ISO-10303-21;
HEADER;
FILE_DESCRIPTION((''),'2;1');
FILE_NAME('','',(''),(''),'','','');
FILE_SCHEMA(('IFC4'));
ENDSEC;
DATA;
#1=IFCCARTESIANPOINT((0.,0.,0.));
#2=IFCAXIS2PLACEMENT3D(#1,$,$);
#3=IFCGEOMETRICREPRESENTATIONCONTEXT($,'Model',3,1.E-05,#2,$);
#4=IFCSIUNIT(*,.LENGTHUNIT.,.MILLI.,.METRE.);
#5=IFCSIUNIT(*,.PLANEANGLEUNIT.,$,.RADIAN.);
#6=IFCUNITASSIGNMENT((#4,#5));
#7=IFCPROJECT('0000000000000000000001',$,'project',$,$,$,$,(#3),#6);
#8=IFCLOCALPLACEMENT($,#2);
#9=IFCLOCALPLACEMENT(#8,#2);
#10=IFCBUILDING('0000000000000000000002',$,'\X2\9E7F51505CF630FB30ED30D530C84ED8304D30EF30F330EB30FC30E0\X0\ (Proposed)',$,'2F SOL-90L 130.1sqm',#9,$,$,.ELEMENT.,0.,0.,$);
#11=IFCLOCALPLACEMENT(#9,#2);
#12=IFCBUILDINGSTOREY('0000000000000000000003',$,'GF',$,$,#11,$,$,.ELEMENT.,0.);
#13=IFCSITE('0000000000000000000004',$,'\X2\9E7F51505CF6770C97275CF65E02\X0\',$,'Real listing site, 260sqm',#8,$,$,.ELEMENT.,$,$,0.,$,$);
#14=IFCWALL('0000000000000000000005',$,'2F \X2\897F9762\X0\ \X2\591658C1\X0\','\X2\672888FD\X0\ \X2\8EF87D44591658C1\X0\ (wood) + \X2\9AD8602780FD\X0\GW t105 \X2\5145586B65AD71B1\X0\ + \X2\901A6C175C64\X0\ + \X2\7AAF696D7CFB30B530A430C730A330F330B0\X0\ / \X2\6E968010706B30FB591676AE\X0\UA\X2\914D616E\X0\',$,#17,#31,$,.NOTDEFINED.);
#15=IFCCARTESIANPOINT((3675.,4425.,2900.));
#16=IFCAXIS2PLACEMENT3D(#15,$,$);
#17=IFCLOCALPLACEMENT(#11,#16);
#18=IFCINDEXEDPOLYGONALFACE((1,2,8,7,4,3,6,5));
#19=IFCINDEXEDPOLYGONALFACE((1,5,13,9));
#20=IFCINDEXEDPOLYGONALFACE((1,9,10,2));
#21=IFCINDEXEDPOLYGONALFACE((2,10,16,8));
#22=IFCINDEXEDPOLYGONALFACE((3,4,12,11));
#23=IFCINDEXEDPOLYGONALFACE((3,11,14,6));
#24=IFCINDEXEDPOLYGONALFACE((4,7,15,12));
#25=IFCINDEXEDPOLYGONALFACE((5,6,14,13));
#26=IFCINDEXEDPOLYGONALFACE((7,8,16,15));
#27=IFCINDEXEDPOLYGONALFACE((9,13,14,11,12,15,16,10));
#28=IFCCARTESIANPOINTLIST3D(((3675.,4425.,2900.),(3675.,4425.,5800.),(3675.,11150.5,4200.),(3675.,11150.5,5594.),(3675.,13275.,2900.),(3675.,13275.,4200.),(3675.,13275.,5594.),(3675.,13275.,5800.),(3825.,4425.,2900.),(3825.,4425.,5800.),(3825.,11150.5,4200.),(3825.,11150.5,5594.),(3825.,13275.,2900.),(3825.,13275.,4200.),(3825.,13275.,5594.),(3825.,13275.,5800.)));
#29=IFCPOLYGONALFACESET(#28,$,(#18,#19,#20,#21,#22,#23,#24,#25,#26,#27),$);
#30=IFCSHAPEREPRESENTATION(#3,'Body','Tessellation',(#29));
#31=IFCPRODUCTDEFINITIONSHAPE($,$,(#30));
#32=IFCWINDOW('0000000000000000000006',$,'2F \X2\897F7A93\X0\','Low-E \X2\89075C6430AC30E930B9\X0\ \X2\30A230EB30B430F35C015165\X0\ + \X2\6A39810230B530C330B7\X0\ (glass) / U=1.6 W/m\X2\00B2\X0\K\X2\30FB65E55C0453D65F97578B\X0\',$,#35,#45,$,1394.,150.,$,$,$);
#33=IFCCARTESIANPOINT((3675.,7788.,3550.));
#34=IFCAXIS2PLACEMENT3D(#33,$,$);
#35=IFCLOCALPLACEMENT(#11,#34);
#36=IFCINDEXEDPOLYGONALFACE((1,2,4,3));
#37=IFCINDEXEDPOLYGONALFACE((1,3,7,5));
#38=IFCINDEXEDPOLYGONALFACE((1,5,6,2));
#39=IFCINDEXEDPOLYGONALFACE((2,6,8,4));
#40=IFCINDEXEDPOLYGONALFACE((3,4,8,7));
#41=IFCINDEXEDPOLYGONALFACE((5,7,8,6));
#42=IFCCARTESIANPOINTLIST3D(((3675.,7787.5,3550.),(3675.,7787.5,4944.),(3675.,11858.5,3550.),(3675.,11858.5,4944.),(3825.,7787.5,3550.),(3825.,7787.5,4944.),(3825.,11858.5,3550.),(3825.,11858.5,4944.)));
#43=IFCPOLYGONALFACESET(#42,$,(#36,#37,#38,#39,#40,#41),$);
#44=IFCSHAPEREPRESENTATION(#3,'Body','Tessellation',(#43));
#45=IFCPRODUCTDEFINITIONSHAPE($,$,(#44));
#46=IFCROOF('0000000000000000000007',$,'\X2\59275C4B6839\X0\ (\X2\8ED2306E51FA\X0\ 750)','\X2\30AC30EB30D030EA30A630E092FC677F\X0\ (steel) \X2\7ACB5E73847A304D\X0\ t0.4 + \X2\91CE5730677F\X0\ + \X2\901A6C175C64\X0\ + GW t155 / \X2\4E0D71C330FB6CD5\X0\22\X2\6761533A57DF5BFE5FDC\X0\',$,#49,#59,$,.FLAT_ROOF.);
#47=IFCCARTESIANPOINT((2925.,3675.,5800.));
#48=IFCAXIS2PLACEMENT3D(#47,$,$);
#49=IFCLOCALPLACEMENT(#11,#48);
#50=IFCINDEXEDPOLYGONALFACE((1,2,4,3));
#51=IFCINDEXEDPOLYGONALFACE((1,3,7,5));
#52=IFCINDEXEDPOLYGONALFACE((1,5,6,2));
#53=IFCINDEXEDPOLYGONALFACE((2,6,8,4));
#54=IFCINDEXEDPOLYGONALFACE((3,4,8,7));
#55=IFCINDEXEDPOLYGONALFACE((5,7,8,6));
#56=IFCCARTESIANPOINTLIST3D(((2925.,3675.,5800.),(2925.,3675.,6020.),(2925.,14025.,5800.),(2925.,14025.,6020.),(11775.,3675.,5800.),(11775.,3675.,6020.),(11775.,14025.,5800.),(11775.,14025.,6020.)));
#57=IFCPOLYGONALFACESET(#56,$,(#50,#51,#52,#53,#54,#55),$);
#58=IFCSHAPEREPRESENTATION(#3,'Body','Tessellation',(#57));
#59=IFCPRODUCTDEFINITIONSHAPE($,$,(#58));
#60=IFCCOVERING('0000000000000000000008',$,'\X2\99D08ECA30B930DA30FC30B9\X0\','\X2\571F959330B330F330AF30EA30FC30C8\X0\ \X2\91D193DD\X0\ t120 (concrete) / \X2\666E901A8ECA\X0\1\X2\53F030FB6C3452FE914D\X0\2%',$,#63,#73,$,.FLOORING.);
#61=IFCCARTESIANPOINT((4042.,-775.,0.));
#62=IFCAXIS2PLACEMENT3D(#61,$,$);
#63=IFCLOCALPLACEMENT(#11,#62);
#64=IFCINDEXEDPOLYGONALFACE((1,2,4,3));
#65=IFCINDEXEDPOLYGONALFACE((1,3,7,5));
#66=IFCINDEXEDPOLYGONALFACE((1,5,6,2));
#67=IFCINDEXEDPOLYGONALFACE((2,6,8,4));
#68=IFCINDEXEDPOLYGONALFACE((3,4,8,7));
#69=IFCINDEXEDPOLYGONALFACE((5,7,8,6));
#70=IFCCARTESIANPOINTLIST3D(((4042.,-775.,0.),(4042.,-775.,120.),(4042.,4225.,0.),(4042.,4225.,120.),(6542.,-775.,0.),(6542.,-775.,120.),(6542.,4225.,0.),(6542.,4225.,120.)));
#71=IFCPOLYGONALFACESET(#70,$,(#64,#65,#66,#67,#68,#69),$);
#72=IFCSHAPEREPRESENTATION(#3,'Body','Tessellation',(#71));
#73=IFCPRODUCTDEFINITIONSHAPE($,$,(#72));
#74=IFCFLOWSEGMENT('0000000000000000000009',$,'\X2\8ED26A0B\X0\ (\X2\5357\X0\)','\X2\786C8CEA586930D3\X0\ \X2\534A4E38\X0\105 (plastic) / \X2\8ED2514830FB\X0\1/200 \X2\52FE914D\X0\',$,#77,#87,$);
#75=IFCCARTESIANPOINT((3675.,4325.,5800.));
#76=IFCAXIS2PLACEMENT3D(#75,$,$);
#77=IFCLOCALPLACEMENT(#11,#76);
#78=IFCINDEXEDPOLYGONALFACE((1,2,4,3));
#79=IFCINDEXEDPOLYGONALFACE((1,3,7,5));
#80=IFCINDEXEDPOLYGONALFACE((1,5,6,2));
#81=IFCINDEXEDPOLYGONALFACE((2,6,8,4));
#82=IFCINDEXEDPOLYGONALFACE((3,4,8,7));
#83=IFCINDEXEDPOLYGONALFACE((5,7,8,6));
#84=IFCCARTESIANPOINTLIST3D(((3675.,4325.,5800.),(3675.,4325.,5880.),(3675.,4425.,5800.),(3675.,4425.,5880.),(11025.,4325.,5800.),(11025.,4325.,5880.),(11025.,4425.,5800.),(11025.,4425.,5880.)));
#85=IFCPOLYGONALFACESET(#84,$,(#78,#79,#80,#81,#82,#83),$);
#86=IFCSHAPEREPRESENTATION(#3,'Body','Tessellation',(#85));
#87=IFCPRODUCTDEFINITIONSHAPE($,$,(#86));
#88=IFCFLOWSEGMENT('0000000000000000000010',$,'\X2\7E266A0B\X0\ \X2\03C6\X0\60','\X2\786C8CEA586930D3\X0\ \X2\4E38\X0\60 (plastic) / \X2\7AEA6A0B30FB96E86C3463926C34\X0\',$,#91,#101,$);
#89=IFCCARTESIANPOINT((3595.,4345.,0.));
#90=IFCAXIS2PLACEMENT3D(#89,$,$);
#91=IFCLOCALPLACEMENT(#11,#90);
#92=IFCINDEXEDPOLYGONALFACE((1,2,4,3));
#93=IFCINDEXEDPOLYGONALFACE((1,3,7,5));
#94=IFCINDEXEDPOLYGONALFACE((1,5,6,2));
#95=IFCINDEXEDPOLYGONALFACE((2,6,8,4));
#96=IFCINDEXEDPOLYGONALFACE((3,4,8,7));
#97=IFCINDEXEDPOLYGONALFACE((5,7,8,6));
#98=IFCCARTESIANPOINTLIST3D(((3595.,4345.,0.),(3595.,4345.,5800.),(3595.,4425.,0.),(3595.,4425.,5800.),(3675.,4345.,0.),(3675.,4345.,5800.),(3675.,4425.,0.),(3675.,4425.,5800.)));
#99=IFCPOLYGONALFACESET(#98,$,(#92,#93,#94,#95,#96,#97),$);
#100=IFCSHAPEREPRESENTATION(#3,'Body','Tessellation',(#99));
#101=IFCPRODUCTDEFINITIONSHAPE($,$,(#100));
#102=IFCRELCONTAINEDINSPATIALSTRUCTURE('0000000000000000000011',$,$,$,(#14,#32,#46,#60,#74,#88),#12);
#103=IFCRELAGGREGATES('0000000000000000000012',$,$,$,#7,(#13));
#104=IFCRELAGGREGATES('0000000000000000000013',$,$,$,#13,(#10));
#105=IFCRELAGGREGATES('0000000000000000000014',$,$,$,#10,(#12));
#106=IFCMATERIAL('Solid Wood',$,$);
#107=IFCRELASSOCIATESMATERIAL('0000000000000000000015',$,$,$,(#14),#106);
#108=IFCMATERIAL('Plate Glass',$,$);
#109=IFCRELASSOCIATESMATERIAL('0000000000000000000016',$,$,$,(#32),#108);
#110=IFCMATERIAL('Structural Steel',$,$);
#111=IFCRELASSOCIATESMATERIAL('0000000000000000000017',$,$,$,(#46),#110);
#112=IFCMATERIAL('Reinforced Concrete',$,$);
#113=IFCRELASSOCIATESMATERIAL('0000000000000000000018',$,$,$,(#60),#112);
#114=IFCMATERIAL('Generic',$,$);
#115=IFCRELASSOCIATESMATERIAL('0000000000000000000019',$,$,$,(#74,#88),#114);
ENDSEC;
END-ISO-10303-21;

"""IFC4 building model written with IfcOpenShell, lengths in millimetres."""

from ifc_helpers import new_model, si_unit, frame, frame_2d, origin, place, context, project, spatial, rectangle, extrude, material, element, fill, save


model = new_model("IFC4")

# Units and contexts
model_context = context("Model", 3, precision=1e-05, world=origin())
ifc_project = project(units=[si_unit("LENGTHUNIT", "METRE", prefix="MILLI"), si_unit("PLANEANGLEUNIT", "RADIAN")], contexts=[model_context])

# Site, building, storey
site_placement = place(None, origin())
site = spatial("IfcSite", under=ifc_project, at=site_placement, Name="鹿児島県霧島市", ObjectType="Real listing site, 260sqm", CompositionType="ELEMENT", RefElevation=0.0)
building_placement = place(site_placement, origin())
building = spatial("IfcBuilding", under=site, at=building_placement, Name="鹿児島・ロフト付きワンルーム (Proposed)", ObjectType="2F SOL-90L 130.1sqm", CompositionType="ELEMENT", ElevationOfRefHeight=0.0, ElevationOfTerrain=0.0)
storey_placement = place(building_placement, origin())
storey = spatial("IfcBuildingStorey", under=building, at=storey_placement, Name="GF", CompositionType="ELEMENT", Elevation=0.0)

# Shared definitions
ifc_material_1 = material(Name="Solid Wood")

# Shared definitions
ifc_material_2 = material(Name="Reinforced Concrete")

# Shared definitions
ifc_material_3 = material(Name="Plate Glass")

# Wall, opening, window
wall_1_placement = place(storey_placement, frame((3675.0, 4425.0, 2900.0)))
wall_1 = element("IfcWall", 1, at=wall_1_placement, inside=storey, material=ifc_material_1, Name="2F 西面 外壁", Description="木製 軸組外壁 (wood) + 高性能GW t105 充填断熱 + 通気層 + 窯業系サイディング / 準耐火・外皮UA配慮", PredefinedType="NOTDEFINED", context=model_context, shape_type="SweptSolid", body=[
    extrude(rectangle(XDim=150.0, YDim=8850.0, at=frame_2d((75.0, 4425.0))), frame((3675.0, 4425.0, 2900.0)), (0.0, 0.0, 1.0), 2900.0),
])
opening_1_placement = place(storey_placement, frame((3675.0, 7788.0, 3550.0)))
opening_1 = element("IfcOpeningElement", 2, at=opening_1_placement, cuts=wall_1, PredefinedType="NOTDEFINED", context=model_context, shape_type="SweptSolid", body=[
    extrude(rectangle(XDim=150.0, YDim=4071.0, at=frame_2d((75.0, 2035.0))), frame((3675.0, 7788.0, 3550.0)), (0.0, 0.0, 1.0), 1394.0),
])
window_1_placement = place(storey_placement, frame((3675.0, 7788.0, 3550.0)))
window_1 = element("IfcWindow", 3, at=window_1_placement, inside=storey, material=ifc_material_3, Name="2F 西窓", Description="Low-E 複層ガラス アルゴン封入 + 樹脂サッシ (glass) / U=1.6 W/m²K・日射取得型", OverallHeight=1394.0, OverallWidth=150.0, context=model_context, shape_type="SweptSolid", body=[
    extrude(rectangle(XDim=150.0, YDim=4071.0, at=frame_2d((75.0, 2035.0))), frame((3675.0, 7788.0, 3550.0)), (0.0, 0.0, 1.0), 1394.0),
])
fill(opening_1, window_1)

# Roof
ifc_material_4 = material(Name="Structural Steel")
roof_placement = place(storey_placement, frame((2925.0, 3675.0, 5800.0)))
element("IfcRoof", 4, at=roof_placement, inside=storey, material=ifc_material_4, Name="大屋根 (軒の出 750)", Description="ガルバリウム鋼板 (steel) 立平葺き t0.4 + 野地板 + 通気層 + GW t155 / 不燃・法22条区域対応", PredefinedType="FLAT_ROOF", context=model_context, shape_type="SweptSolid", body=[
    extrude(rectangle(XDim=8850.0, YDim=10350.0, at=frame_2d((4425.0, 5175.0))), frame((2925.0, 3675.0, 5800.0)), (0.0, 0.0, 1.0), 220.0),
])

# Covering
covering_placement = place(storey_placement, frame((4042.0, -775.0, 0.0)))
element("IfcCovering", 5, at=covering_placement, inside=storey, material=ifc_material_2, Name="駐車スペース", Description="土間コンクリート 金鏝 t120 (concrete) / 普通車1台・水勾配2%", PredefinedType="FLOORING", context=model_context, shape_type="SweptSolid", body=[
    extrude(rectangle(XDim=2500.0, YDim=5000.0, at=frame_2d((1250.0, 2500.0))), frame((4042.0, -775.0, 0.0)), (0.0, 0.0, 1.0), 120.0),
])

# Flow segments
ifc_material_5 = material(Name="Generic")
flow_segment_1_placement = place(storey_placement, frame((3675.0, 4325.0, 5800.0)))
element("IfcFlowSegment", 6, at=flow_segment_1_placement, inside=storey, material=ifc_material_5, Name="軒樋 (南)", Description="硬質塩ビ 半丸105 (plastic) / 軒先・1/200 勾配", context=model_context, shape_type="SweptSolid", body=[
    extrude(rectangle(XDim=7350.0, YDim=100.0, at=frame_2d((3675.0, 50.0))), frame((3675.0, 4325.0, 5800.0)), (0.0, 0.0, 1.0), 80.0),
])
flow_segment_2_placement = place(storey_placement, frame((3595.0, 4345.0, 0.0)))
element("IfcFlowSegment", 7, at=flow_segment_2_placement, inside=storey, material=ifc_material_5, Name="縦樋 φ60", Description="硬質塩ビ 丸60 (plastic) / 竪樋・雨水排水", context=model_context, shape_type="SweptSolid", body=[
    extrude(rectangle(XDim=80.0, YDim=80.0, at=frame_2d((40.0, 40.0))), frame((3595.0, 4345.0, 0.0)), (0.0, 0.0, 1.0), 5800.0),
])

save(model, "model.ifc")
